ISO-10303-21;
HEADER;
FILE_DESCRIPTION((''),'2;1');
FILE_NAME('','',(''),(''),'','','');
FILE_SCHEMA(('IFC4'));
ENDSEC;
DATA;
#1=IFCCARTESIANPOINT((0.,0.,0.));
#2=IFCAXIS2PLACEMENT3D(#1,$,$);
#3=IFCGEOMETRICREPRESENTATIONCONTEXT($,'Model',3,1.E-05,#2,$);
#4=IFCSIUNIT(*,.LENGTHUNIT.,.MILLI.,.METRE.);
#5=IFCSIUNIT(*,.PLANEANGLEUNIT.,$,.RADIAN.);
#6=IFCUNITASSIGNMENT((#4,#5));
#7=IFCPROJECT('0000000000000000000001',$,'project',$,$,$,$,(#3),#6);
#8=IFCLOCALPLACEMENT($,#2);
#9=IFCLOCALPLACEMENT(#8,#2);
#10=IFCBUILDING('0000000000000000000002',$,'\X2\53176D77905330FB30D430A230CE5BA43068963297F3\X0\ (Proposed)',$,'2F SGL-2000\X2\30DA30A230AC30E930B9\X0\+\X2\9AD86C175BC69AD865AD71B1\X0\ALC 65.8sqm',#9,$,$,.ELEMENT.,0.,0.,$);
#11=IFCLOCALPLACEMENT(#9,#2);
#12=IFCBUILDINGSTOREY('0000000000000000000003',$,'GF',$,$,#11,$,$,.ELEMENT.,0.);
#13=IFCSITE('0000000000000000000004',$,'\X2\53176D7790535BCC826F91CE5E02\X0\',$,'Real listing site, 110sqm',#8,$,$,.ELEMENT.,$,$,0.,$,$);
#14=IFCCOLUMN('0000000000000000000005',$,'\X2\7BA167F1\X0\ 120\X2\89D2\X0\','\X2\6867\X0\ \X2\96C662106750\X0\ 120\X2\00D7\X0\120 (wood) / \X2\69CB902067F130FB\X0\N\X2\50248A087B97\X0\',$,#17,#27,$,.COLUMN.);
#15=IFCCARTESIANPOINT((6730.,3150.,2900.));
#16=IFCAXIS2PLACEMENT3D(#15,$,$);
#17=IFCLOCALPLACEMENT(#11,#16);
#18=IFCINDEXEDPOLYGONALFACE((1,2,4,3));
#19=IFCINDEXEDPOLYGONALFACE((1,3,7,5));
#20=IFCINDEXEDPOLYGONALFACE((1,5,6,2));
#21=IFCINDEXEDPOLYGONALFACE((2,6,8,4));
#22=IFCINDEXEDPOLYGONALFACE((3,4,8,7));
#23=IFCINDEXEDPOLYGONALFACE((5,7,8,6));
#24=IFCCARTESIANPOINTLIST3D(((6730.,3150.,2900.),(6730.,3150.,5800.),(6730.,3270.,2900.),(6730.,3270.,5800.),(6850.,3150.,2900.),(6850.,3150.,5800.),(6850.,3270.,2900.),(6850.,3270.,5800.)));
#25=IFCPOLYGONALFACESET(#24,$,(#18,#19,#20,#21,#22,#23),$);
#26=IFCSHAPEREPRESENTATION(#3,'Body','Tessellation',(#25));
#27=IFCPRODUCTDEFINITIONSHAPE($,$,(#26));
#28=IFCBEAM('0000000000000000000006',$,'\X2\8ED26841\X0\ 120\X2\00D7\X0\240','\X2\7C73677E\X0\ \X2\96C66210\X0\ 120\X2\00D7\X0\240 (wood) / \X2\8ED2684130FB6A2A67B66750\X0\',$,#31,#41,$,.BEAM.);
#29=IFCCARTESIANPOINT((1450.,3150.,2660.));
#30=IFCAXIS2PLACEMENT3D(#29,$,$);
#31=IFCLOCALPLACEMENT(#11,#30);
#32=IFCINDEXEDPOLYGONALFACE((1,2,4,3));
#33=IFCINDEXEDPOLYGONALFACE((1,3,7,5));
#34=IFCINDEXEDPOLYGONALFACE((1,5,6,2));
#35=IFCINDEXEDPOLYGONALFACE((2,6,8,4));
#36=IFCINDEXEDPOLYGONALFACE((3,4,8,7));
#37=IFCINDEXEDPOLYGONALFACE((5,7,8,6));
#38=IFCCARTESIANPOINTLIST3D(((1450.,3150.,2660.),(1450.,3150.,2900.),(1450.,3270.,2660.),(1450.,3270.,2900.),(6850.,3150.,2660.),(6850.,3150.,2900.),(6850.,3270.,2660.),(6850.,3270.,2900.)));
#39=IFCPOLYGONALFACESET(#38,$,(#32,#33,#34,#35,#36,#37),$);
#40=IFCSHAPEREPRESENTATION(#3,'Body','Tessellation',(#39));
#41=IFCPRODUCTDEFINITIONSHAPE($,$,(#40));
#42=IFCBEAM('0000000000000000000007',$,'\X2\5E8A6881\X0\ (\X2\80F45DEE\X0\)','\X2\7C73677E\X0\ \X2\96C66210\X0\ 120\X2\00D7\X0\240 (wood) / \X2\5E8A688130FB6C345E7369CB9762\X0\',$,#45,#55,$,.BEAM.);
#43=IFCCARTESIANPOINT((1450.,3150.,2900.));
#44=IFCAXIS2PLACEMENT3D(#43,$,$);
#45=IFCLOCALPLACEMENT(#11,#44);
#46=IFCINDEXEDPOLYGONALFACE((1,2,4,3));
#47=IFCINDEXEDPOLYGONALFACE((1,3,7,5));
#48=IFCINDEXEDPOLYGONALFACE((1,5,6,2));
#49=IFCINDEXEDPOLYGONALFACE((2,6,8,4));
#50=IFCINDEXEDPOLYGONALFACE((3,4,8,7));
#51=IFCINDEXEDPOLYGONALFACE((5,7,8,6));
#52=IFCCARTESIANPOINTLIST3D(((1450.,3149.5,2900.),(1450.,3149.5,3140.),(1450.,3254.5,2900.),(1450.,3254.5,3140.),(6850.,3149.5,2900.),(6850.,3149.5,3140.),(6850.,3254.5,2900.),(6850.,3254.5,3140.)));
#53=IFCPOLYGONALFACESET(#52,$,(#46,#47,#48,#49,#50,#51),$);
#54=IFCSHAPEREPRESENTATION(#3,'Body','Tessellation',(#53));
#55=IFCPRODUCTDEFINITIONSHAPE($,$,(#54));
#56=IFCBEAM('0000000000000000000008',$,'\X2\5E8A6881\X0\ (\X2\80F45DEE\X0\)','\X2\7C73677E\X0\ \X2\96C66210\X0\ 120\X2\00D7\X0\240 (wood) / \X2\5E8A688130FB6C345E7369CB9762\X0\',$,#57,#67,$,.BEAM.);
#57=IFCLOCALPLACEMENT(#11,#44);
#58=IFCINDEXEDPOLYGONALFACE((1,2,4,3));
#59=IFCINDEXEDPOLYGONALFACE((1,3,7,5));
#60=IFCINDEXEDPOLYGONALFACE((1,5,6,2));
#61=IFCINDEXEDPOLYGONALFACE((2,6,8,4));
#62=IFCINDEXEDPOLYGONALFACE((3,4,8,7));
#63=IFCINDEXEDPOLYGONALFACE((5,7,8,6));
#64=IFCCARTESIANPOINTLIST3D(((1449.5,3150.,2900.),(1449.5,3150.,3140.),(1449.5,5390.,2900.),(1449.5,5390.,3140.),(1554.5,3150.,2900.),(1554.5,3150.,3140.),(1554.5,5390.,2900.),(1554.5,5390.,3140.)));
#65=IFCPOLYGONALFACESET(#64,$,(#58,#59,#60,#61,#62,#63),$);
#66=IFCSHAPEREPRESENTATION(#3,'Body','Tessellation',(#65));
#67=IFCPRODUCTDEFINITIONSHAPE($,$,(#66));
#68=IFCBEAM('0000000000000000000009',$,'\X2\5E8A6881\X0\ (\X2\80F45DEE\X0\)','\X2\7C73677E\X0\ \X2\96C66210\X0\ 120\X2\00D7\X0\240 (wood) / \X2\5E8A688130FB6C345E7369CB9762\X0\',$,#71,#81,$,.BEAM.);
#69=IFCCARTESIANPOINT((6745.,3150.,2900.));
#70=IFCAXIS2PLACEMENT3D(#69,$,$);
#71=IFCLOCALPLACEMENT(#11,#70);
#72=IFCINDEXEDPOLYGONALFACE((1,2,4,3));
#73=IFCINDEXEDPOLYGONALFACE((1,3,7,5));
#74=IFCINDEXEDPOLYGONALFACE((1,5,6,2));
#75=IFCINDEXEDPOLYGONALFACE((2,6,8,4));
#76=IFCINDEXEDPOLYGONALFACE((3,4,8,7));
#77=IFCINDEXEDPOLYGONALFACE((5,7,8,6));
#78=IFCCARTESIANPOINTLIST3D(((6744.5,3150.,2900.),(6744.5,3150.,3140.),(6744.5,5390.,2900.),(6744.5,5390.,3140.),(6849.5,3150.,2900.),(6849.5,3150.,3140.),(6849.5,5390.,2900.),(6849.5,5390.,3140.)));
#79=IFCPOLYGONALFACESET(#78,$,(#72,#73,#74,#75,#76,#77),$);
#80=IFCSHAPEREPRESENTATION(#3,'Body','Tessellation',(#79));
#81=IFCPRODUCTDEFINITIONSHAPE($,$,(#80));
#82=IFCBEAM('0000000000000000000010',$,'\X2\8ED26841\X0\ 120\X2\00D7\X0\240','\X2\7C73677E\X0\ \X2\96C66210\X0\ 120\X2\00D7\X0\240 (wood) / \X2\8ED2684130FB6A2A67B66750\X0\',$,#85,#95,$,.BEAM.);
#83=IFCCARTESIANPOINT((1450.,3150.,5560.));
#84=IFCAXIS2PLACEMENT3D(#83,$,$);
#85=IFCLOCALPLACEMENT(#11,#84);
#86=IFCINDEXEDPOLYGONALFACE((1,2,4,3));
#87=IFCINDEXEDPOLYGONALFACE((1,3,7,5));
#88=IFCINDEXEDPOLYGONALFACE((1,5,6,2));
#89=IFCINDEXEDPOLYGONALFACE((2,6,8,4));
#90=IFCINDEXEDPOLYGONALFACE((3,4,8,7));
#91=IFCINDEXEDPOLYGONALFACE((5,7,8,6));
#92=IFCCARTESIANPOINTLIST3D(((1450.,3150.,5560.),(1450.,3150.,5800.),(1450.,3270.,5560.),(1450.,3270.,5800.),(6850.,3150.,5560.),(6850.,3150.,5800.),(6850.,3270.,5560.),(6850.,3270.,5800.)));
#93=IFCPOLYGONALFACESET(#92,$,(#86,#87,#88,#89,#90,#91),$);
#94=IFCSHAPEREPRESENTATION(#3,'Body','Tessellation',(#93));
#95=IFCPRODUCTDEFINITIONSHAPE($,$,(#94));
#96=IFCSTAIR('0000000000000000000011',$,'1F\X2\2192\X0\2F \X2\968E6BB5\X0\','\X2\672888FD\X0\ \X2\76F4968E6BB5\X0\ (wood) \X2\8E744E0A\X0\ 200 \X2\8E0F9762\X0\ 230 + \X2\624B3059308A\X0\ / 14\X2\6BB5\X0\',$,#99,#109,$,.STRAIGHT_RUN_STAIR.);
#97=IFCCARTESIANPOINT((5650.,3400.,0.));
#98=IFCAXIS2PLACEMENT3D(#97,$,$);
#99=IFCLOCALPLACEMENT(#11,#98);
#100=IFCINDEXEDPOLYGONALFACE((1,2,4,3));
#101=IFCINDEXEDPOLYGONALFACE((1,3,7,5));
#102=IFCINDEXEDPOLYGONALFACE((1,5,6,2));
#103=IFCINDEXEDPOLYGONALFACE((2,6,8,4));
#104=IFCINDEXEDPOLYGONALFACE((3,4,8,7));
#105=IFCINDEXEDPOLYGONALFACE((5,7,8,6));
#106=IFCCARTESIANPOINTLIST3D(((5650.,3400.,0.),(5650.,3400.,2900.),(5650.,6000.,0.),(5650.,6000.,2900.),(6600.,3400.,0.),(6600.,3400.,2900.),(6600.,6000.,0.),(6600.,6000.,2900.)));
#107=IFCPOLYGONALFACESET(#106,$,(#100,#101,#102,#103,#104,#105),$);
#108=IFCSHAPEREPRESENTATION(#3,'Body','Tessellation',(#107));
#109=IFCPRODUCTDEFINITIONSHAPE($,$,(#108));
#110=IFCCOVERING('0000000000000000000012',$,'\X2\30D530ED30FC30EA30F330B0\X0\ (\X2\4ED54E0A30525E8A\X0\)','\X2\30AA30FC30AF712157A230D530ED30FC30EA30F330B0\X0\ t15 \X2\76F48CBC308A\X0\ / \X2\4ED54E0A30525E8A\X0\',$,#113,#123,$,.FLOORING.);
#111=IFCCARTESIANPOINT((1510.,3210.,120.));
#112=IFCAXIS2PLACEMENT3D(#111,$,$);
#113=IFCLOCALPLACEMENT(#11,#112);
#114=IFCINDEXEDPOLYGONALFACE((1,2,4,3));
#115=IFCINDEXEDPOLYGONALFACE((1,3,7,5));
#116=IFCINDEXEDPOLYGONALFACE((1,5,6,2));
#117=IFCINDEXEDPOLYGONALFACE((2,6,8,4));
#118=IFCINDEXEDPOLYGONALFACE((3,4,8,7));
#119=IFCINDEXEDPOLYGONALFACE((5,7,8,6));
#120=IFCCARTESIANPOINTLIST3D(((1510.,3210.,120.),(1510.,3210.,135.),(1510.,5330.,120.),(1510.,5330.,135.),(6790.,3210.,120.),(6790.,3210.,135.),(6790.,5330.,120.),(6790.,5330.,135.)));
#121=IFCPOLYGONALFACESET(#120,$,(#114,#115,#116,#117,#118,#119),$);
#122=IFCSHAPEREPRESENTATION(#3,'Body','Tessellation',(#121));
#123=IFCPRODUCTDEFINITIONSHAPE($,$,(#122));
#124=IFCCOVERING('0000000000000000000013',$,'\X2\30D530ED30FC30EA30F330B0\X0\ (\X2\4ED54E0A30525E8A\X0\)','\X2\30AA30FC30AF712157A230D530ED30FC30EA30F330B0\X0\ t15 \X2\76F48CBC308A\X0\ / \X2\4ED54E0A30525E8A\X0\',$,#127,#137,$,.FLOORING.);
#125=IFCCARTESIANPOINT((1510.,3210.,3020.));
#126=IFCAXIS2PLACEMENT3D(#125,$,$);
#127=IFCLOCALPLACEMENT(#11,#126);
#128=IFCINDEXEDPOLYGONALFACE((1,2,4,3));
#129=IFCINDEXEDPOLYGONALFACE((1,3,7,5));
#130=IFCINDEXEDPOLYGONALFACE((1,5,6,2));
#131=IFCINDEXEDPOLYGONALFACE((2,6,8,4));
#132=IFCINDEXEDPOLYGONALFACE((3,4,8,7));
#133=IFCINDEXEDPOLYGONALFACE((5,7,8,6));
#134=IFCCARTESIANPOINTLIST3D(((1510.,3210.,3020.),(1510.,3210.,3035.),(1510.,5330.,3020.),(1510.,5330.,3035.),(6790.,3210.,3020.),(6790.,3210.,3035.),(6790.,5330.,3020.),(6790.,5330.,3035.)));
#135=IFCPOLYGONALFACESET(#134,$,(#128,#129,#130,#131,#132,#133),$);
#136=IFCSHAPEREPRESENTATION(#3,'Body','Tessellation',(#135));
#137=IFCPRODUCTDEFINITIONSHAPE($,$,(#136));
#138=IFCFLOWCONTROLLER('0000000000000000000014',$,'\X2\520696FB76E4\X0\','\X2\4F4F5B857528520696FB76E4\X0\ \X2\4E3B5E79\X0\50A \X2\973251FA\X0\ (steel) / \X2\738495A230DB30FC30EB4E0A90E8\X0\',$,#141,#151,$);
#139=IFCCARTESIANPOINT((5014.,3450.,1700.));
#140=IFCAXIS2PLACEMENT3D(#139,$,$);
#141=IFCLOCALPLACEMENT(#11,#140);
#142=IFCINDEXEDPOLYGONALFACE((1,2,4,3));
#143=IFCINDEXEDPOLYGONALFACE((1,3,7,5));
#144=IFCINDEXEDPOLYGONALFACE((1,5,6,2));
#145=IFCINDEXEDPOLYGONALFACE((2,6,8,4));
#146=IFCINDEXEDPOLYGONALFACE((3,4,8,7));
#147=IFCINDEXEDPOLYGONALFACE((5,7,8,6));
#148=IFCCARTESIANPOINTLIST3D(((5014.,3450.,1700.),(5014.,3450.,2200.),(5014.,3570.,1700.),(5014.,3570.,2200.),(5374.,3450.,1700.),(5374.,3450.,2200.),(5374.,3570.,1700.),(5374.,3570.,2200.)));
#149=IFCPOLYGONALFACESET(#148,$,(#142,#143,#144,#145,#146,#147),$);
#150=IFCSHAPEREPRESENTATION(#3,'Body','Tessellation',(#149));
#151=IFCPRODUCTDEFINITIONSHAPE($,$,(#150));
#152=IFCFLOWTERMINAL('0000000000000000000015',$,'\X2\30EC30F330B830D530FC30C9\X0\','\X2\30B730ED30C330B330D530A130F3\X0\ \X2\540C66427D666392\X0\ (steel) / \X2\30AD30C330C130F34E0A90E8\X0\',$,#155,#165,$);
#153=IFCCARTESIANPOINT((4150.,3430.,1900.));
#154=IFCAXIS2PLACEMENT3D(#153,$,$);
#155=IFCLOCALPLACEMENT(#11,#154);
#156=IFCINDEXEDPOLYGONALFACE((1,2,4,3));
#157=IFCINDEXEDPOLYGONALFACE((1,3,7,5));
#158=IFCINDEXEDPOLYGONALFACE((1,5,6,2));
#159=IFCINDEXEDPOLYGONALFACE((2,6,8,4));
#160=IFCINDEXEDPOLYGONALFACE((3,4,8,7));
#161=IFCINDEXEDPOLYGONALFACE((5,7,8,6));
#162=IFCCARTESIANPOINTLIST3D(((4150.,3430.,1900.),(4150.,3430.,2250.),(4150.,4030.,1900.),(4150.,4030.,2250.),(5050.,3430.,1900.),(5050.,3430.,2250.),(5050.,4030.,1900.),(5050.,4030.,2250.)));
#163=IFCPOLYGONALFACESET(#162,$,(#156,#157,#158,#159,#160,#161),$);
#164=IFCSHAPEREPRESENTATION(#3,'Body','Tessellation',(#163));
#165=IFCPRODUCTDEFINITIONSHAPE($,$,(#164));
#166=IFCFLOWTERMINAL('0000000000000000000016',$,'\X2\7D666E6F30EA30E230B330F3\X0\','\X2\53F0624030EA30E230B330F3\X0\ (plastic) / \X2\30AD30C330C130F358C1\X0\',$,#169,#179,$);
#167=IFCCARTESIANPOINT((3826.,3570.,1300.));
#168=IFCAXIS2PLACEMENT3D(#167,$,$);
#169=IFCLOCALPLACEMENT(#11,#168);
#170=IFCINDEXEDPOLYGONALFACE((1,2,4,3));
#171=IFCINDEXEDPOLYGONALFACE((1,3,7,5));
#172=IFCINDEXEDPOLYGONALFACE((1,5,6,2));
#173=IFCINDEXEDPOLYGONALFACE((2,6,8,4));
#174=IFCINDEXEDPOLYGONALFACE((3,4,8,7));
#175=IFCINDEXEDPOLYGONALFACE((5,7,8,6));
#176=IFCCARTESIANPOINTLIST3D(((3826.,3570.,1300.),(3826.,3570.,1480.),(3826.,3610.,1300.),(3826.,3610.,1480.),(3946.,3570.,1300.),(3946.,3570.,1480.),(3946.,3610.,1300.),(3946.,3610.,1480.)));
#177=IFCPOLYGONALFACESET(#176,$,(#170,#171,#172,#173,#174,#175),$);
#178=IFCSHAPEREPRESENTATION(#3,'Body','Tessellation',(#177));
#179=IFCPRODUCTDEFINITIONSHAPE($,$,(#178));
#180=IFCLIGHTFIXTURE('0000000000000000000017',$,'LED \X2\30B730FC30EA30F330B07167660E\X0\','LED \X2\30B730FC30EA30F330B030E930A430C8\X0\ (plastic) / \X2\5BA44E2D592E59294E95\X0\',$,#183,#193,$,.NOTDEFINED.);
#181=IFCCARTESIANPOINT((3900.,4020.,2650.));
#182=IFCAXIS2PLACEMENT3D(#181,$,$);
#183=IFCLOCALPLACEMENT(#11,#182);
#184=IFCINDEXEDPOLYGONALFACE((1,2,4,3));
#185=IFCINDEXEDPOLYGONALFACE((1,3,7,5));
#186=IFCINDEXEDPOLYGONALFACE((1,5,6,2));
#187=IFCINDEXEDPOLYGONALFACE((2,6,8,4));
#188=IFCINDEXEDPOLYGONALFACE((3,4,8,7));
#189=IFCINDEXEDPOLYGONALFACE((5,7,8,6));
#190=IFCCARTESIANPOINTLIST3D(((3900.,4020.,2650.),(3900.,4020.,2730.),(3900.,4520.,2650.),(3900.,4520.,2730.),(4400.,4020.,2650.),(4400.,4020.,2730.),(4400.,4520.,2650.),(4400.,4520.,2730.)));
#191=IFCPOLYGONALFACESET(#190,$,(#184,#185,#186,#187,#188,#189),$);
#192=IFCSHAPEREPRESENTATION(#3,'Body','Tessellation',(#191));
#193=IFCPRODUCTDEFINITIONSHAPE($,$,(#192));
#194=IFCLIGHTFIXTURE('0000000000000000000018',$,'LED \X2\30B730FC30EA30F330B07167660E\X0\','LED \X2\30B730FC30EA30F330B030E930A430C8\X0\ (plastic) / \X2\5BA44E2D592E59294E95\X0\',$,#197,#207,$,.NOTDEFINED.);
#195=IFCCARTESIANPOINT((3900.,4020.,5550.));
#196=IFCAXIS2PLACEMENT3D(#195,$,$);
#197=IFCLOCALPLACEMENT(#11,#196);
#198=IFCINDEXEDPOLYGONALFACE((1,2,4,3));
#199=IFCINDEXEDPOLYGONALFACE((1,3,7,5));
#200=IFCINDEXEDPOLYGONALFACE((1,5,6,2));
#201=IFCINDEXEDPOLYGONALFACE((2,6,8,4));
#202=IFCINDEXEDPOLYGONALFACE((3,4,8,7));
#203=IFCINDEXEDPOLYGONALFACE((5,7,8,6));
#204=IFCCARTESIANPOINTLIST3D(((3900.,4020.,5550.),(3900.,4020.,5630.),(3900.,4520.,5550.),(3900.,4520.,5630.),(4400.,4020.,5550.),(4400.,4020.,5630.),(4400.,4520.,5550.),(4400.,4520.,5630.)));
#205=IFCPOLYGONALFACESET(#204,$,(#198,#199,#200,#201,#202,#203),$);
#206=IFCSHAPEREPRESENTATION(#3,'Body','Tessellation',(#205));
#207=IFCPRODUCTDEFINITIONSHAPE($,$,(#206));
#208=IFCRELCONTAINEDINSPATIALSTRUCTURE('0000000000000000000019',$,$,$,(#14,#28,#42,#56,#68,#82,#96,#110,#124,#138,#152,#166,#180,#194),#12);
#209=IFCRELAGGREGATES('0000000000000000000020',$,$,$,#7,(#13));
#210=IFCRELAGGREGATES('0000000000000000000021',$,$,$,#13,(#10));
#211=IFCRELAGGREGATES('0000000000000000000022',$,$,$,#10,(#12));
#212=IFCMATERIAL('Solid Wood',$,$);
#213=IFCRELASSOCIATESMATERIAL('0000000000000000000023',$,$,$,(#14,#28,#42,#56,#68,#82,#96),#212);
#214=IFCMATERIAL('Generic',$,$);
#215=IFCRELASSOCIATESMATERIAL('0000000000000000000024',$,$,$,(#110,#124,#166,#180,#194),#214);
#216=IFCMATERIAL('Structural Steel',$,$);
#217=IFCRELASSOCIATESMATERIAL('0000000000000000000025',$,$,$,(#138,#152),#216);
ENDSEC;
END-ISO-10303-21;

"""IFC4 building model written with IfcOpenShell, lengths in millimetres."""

from ifc_helpers import new_model, si_unit, frame, frame_2d, origin, place, context, project, spatial, rectangle, extrude, material, element, save


model = new_model("IFC4")

# Units and contexts
model_context = context("Model", 3, precision=1e-05, world=origin())
ifc_project = project(units=[si_unit("LENGTHUNIT", "METRE", prefix="MILLI"), si_unit("PLANEANGLEUNIT", "RADIAN")], contexts=[model_context])

# Site, building, storey
site_placement = place(None, origin())
site = spatial("IfcSite", under=ifc_project, at=site_placement, Name="北海道富良野市", ObjectType="Real listing site, 110sqm", CompositionType="ELEMENT", RefElevation=0.0)
building_placement = place(site_placement, origin())
building = spatial("IfcBuilding", under=site, at=building_placement, Name="北海道・ピアノ室と防音 (Proposed)", ObjectType="2F SGL-2000ペアガラス+高気密高断熱ALC 65.8sqm", CompositionType="ELEMENT", ElevationOfRefHeight=0.0, ElevationOfTerrain=0.0)
storey_placement = place(building_placement, origin())
storey = spatial("IfcBuildingStorey", under=building, at=storey_placement, Name="GF", CompositionType="ELEMENT", Elevation=0.0)

# Column
ifc_material_1 = material(Name="Solid Wood")
column_1_placement = place(storey_placement, frame((6730.0, 3150.0, 2900.0)))
element("IfcColumn", 1, at=column_1_placement, inside=storey, material=ifc_material_1, Name="管柱 120角", Description="桧 集成材 120×120 (wood) / 構造柱・N値計算", PredefinedType="COLUMN", context=model_context, shape_type="SweptSolid", body=[
    extrude(rectangle(XDim=120.0, YDim=120.0, at=frame_2d((60.0, 60.0))), frame((6730.0, 3150.0, 2900.0)), (0.0, 0.0, 1.0), 2900.0),
])

# Beams
beam_1_placement = place(storey_placement, frame((1450.0, 3150.0, 2660.0)))
element("IfcBeam", 2, at=beam_1_placement, inside=storey, material=ifc_material_1, Name="軒桁 120×240", Description="米松 集成 120×240 (wood) / 軒桁・横架材", PredefinedType="BEAM", context=model_context, shape_type="SweptSolid", body=[
    extrude(rectangle(XDim=5400.0, YDim=120.0, at=frame_2d((2700.0, 60.0))), frame((1450.0, 3150.0, 2660.0)), (0.0, 0.0, 1.0), 240.0),
])
beam_2_placement = place(storey_placement, frame((1450.0, 3150.0, 2900.0)))
element("IfcBeam", 3, at=beam_2_placement, inside=storey, material=ifc_material_1, Name="床梁 (胴差)", Description="米松 集成 120×240 (wood) / 床梁・水平構面", PredefinedType="BEAM", context=model_context, shape_type="SweptSolid", body=[
    extrude(rectangle(XDim=5400.0, YDim=105.0, at=frame_2d((2700.0, 52.0))), frame((1450.0, 3150.0, 2900.0)), (0.0, 0.0, 1.0), 240.0),
])
beam_3_placement = place(storey_placement, frame((1450.0, 3150.0, 2900.0)))
element("IfcBeam", 4, at=beam_3_placement, inside=storey, material=ifc_material_1, Name="床梁 (胴差)", Description="米松 集成 120×240 (wood) / 床梁・水平構面", PredefinedType="BEAM", context=model_context, shape_type="SweptSolid", body=[
    extrude(rectangle(XDim=105.0, YDim=2240.0, at=frame_2d((52.0, 1120.0))), frame((1450.0, 3150.0, 2900.0)), (0.0, 0.0, 1.0), 240.0),
])
beam_4_placement = place(storey_placement, frame((6745.0, 3150.0, 2900.0)))
element("IfcBeam", 5, at=beam_4_placement, inside=storey, material=ifc_material_1, Name="床梁 (胴差)", Description="米松 集成 120×240 (wood) / 床梁・水平構面", PredefinedType="BEAM", context=model_context, shape_type="SweptSolid", body=[
    extrude(rectangle(XDim=105.0, YDim=2240.0, at=frame_2d((52.0, 1120.0))), frame((6745.0, 3150.0, 2900.0)), (0.0, 0.0, 1.0), 240.0),
])
beam_5_placement = place(storey_placement, frame((1450.0, 3150.0, 5560.0)))
element("IfcBeam", 6, at=beam_5_placement, inside=storey, material=ifc_material_1, Name="軒桁 120×240", Description="米松 集成 120×240 (wood) / 軒桁・横架材", PredefinedType="BEAM", context=model_context, shape_type="SweptSolid", body=[
    extrude(rectangle(XDim=5400.0, YDim=120.0, at=frame_2d((2700.0, 60.0))), frame((1450.0, 3150.0, 5560.0)), (0.0, 0.0, 1.0), 240.0),
])

# Stair
stair_placement = place(storey_placement, frame((5650.0, 3400.0, 0.0)))
element("IfcStair", 7, at=stair_placement, inside=storey, material=ifc_material_1, Name="1F→2F 階段", Description="木製 直階段 (wood) 蹴上 200 踏面 230 + 手すり / 14段", PredefinedType="STRAIGHT_RUN_STAIR", context=model_context, shape_type="SweptSolid", body=[
    extrude(rectangle(XDim=950.0, YDim=2600.0, at=frame_2d((475.0, 1300.0))), frame((5650.0, 3400.0, 0.0)), (0.0, 0.0, 1.0), 2900.0),
])

# Coverings
ifc_material_2 = material(Name="Generic")
covering_1_placement = place(storey_placement, frame((1510.0, 3210.0, 120.0)))
element("IfcCovering", 8, at=covering_1_placement, inside=storey, material=ifc_material_2, Name="フローリング (仕上げ床)", Description="オーク無垢フローリング t15 直貼り / 仕上げ床", PredefinedType="FLOORING", context=model_context, shape_type="SweptSolid", body=[
    extrude(rectangle(XDim=5280.0, YDim=2120.0, at=frame_2d((2640.0, 1060.0))), frame((1510.0, 3210.0, 120.0)), (0.0, 0.0, 1.0), 15.0),
])
covering_2_placement = place(storey_placement, frame((1510.0, 3210.0, 3020.0)))
element("IfcCovering", 9, at=covering_2_placement, inside=storey, material=ifc_material_2, Name="フローリング (仕上げ床)", Description="オーク無垢フローリング t15 直貼り / 仕上げ床", PredefinedType="FLOORING", context=model_context, shape_type="SweptSolid", body=[
    extrude(rectangle(XDim=5280.0, YDim=2120.0, at=frame_2d((2640.0, 1060.0))), frame((1510.0, 3210.0, 3020.0)), (0.0, 0.0, 1.0), 15.0),
])

# Flow controller
ifc_material_3 = material(Name="Structural Steel")
flow_controller_placement = place(storey_placement, frame((5014.0, 3450.0, 1700.0)))
element("IfcFlowController", 10, at=flow_controller_placement, inside=storey, material=ifc_material_3, Name="分電盤", Description="住宅用分電盤 主幹50A 露出 (steel) / 玄関ホール上部", context=model_context, shape_type="SweptSolid", body=[
    extrude(rectangle(XDim=360.0, YDim=120.0, at=frame_2d((180.0, 60.0))), frame((5014.0, 3450.0, 1700.0)), (0.0, 0.0, 1.0), 500.0),
])

# Flow terminals
flow_terminal_1_placement = place(storey_placement, frame((4150.0, 3430.0, 1900.0)))
element("IfcFlowTerminal", 11, at=flow_terminal_1_placement, inside=storey, material=ifc_material_3, Name="レンジフード", Description="シロッコファン 同時給排 (steel) / キッチン上部", context=model_context, shape_type="SweptSolid", body=[
    extrude(rectangle(XDim=900.0, YDim=600.0, at=frame_2d((450.0, 300.0))), frame((4150.0, 3430.0, 1900.0)), (0.0, 0.0, 1.0), 350.0),
])
flow_terminal_2_placement = place(storey_placement, frame((3826.0, 3570.0, 1300.0)))
element("IfcFlowTerminal", 12, at=flow_terminal_2_placement, inside=storey, material=ifc_material_2, Name="給湯リモコン", Description="台所リモコン (plastic) / キッチン壁", context=model_context, shape_type="SweptSolid", body=[
    extrude(rectangle(XDim=120.0, YDim=40.0, at=frame_2d((60.0, 20.0))), frame((3826.0, 3570.0, 1300.0)), (0.0, 0.0, 1.0), 180.0),
])

# Light fixtures
light_fixture_1_placement = place(storey_placement, frame((3900.0, 4020.0, 2650.0)))
element("IfcLightFixture", 13, at=light_fixture_1_placement, inside=storey, material=ifc_material_2, Name="LED シーリング照明", Description="LED シーリングライト (plastic) / 室中央天井", PredefinedType="NOTDEFINED", context=model_context, shape_type="SweptSolid", body=[
    extrude(rectangle(XDim=500.0, YDim=500.0, at=frame_2d((250.0, 250.0))), frame((3900.0, 4020.0, 2650.0)), (0.0, 0.0, 1.0), 80.0),
])
light_fixture_2_placement = place(storey_placement, frame((3900.0, 4020.0, 5550.0)))
element("IfcLightFixture", 14, at=light_fixture_2_placement, inside=storey, material=ifc_material_2, Name="LED シーリング照明", Description="LED シーリングライト (plastic) / 室中央天井", PredefinedType="NOTDEFINED", context=model_context, shape_type="SweptSolid", body=[
    extrude(rectangle(XDim=500.0, YDim=500.0, at=frame_2d((250.0, 250.0))), frame((3900.0, 4020.0, 5550.0)), (0.0, 0.0, 1.0), 80.0),
])

save(model, "model.ifc")
